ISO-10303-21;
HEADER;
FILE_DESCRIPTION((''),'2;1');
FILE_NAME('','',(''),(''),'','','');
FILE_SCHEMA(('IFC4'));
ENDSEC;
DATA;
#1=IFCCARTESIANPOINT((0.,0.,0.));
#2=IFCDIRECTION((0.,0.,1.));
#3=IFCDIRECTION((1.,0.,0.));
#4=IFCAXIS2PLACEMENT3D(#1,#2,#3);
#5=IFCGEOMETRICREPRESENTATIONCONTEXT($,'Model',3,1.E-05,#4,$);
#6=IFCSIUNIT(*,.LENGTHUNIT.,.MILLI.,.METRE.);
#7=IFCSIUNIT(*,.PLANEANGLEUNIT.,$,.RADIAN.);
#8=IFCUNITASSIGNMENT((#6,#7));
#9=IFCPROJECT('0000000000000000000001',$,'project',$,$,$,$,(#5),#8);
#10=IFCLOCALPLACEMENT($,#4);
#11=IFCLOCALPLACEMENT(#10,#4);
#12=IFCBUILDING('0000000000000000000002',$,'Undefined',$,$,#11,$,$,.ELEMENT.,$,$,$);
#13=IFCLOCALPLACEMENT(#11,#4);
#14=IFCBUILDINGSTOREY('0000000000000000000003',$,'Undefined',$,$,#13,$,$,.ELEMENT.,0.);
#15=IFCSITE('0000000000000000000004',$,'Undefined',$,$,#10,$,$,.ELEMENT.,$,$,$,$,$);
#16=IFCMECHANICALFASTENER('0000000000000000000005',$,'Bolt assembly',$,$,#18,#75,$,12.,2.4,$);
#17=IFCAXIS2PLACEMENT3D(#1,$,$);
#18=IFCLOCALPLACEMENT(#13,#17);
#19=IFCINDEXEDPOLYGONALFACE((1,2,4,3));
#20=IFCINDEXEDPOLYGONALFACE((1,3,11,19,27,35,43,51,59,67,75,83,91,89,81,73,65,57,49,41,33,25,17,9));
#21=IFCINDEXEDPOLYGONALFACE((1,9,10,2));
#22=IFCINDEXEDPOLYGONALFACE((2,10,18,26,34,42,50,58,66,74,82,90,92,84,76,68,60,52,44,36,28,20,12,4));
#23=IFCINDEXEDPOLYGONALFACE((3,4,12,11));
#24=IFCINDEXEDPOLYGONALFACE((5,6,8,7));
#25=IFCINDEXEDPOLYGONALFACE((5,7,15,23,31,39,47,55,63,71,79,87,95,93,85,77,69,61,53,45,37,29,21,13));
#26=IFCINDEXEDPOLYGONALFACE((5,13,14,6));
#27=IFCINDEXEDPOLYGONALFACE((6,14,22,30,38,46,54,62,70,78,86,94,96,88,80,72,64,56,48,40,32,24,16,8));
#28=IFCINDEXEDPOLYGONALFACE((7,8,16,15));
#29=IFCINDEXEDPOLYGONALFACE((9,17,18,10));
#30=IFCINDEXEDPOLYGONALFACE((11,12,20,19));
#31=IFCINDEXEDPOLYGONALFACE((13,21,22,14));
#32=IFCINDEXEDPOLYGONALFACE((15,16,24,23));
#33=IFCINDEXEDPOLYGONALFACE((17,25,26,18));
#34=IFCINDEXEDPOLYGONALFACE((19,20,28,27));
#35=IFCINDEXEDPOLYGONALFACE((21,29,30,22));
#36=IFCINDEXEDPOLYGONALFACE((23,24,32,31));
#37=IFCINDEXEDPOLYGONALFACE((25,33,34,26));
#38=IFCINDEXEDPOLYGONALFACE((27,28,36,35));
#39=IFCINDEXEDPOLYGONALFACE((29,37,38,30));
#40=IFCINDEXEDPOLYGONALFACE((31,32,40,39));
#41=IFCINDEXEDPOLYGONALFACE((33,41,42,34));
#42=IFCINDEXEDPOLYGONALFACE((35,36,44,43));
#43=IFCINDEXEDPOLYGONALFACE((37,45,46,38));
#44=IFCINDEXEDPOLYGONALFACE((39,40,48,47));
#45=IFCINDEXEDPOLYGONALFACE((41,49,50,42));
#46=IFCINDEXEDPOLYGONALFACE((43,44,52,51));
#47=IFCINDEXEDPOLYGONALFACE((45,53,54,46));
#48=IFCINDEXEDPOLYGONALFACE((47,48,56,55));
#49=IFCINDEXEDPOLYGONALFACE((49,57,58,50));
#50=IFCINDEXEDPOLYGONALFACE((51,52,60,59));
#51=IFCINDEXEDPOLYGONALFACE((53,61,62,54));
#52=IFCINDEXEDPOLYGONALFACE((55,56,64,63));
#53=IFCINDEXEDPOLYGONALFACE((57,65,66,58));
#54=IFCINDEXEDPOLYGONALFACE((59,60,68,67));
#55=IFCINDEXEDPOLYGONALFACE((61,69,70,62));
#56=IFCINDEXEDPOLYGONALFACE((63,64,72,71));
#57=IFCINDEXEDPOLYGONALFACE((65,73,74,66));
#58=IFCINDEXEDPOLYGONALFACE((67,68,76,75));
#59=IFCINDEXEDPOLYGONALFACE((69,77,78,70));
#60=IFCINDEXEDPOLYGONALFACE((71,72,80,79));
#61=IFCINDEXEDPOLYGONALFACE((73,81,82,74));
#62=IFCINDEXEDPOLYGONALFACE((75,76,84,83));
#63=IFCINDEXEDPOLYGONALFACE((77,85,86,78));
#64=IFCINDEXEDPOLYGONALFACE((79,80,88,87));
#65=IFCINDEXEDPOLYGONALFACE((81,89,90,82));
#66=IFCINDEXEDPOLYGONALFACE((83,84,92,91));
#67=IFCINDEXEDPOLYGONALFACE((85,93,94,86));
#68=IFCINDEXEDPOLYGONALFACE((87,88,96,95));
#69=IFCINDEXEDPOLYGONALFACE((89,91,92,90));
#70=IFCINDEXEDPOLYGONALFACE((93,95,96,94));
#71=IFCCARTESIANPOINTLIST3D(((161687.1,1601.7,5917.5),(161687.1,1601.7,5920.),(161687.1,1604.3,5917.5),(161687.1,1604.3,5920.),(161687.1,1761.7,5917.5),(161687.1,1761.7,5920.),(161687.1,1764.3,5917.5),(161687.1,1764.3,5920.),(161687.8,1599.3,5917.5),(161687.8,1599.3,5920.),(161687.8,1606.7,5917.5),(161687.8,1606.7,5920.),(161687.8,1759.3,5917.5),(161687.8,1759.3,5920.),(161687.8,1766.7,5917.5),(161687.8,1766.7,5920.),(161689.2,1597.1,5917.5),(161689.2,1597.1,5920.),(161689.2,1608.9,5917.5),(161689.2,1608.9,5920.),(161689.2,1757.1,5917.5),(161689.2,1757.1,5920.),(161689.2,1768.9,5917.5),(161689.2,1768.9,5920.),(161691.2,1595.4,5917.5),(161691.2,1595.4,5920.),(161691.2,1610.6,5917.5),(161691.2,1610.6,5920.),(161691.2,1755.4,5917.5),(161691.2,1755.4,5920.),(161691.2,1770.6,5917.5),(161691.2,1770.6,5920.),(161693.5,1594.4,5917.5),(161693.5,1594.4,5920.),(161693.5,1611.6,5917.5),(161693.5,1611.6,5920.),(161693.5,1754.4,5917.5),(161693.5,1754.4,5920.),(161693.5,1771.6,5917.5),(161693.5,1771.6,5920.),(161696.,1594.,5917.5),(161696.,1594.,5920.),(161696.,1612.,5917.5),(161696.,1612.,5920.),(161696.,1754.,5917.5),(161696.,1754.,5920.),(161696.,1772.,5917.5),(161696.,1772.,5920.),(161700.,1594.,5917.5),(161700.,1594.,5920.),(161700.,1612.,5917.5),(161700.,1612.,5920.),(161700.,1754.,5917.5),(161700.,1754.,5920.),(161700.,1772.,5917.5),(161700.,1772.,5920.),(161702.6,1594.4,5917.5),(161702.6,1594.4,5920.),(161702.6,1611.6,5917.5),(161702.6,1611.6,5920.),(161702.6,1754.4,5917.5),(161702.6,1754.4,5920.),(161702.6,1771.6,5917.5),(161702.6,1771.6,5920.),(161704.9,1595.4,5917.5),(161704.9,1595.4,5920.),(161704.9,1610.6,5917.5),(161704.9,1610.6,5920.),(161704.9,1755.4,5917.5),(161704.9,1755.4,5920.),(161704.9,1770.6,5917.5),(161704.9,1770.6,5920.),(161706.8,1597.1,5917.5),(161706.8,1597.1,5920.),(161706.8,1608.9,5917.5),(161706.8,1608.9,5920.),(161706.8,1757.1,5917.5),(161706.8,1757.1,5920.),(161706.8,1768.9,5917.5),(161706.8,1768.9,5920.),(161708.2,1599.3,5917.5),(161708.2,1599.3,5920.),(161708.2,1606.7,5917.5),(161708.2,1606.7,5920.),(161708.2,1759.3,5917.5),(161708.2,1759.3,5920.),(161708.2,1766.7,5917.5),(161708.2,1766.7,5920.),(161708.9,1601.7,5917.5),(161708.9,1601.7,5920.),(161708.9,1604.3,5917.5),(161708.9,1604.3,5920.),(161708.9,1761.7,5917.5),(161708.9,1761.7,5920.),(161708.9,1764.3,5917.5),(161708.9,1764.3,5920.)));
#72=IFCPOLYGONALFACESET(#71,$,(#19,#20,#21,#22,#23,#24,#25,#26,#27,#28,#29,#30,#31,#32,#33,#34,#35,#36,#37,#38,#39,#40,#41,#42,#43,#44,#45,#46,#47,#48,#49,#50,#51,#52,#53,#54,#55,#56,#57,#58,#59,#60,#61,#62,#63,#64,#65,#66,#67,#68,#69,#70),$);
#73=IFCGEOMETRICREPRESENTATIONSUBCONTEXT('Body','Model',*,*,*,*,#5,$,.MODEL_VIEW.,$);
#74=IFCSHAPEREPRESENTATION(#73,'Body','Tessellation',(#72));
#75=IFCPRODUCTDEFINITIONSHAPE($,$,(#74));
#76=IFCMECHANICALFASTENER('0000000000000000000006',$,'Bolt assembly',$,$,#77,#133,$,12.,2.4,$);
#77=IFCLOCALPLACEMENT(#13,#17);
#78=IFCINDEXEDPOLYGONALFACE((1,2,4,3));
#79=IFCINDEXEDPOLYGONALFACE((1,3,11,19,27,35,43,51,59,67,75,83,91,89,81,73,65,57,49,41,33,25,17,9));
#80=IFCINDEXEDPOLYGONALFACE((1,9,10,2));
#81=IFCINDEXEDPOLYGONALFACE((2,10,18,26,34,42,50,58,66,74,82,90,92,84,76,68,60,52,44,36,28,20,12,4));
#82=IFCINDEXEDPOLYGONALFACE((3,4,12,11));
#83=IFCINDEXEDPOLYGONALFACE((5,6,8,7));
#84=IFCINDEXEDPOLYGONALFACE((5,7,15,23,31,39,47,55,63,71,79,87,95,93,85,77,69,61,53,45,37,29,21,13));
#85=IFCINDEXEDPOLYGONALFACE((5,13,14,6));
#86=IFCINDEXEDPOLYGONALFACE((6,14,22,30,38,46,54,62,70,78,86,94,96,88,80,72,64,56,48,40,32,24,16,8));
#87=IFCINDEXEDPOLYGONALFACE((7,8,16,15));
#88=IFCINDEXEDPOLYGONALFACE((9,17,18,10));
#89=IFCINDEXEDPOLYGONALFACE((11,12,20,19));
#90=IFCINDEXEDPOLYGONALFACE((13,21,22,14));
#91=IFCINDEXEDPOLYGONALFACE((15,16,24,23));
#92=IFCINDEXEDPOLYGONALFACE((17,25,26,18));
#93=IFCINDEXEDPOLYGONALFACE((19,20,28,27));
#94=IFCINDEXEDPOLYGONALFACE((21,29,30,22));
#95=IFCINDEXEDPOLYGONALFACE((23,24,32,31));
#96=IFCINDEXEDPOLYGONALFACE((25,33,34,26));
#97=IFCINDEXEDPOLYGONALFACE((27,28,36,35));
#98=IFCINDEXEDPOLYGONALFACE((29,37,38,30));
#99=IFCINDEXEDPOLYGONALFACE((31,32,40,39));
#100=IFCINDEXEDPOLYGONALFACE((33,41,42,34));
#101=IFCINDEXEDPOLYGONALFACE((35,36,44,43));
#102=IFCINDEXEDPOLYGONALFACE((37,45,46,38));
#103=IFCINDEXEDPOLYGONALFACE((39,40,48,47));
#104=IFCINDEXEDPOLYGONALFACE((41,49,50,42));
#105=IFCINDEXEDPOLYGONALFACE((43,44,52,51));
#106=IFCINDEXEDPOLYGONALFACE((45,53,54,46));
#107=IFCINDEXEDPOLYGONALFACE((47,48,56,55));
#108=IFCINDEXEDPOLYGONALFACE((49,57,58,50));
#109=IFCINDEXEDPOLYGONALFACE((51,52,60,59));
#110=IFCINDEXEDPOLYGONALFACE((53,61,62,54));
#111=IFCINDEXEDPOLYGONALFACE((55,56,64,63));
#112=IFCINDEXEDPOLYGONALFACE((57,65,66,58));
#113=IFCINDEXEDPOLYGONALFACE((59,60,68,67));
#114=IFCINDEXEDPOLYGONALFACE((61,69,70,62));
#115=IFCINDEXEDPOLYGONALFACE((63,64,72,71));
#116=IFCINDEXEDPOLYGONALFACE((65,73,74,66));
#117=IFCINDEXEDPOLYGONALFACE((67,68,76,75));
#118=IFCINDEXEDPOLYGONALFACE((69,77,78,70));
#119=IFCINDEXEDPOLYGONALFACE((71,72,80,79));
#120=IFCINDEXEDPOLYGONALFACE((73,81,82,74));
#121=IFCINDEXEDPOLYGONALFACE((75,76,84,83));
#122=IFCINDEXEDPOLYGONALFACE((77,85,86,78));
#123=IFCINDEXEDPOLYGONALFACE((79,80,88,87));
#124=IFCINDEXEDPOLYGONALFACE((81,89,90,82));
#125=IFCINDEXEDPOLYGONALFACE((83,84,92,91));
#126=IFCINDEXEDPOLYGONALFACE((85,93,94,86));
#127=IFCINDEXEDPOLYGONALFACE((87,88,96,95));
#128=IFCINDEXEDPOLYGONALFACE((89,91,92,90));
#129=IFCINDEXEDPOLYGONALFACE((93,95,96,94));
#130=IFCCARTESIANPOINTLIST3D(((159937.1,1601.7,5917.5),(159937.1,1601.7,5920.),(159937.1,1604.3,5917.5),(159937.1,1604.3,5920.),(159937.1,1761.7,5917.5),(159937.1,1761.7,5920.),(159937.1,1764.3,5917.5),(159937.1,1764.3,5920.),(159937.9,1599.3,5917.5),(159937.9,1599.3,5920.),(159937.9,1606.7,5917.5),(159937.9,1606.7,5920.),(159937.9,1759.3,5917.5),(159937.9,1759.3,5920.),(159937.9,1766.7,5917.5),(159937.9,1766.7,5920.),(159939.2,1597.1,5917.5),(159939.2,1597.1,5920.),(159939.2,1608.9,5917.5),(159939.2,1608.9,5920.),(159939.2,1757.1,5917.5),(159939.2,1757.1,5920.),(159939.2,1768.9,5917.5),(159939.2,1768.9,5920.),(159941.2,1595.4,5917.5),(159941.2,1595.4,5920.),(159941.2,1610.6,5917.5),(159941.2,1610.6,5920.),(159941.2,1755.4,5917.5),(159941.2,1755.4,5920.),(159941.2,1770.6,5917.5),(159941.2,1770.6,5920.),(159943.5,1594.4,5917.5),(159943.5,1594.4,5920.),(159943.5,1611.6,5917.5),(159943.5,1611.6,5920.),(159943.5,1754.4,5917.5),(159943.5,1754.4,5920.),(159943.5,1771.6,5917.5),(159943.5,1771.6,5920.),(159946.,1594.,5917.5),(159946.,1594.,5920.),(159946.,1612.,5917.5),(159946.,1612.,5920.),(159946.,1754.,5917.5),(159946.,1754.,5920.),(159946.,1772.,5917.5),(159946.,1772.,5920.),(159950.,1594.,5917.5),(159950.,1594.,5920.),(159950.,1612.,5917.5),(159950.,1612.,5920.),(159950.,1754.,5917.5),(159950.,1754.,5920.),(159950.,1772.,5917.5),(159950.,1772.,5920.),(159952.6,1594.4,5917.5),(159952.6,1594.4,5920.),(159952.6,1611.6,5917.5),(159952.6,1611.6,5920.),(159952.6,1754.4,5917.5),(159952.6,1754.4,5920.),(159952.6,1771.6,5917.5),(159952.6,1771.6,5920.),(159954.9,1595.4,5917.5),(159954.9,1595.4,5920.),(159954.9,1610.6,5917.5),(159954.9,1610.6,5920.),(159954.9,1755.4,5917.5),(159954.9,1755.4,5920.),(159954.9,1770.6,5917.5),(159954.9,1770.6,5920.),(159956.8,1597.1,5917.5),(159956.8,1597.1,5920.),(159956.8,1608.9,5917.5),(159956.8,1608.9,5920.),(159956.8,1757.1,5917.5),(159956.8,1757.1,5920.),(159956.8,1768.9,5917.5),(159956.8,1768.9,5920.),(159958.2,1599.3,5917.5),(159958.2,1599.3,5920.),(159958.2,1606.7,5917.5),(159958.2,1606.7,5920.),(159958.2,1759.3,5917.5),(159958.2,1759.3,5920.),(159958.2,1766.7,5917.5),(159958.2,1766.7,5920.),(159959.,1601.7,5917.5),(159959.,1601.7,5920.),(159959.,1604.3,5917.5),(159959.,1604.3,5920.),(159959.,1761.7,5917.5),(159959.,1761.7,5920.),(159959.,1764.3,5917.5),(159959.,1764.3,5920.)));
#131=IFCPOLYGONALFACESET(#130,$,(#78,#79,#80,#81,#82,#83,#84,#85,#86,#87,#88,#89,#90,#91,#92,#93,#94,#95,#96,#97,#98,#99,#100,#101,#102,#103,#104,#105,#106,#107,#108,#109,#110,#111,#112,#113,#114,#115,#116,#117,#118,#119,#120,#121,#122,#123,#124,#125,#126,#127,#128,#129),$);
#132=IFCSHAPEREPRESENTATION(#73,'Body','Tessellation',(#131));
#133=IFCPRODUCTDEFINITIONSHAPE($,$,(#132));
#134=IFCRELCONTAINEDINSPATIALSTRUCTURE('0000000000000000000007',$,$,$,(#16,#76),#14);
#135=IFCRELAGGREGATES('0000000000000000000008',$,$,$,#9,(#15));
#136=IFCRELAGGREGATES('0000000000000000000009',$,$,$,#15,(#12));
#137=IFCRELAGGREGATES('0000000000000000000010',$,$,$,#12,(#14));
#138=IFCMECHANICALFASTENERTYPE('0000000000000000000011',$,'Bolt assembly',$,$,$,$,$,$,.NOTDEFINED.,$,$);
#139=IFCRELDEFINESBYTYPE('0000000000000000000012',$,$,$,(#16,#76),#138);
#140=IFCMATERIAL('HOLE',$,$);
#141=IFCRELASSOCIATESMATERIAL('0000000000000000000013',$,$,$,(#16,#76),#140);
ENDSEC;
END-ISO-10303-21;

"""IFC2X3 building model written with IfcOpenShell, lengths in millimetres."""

from ifc_helpers import new_model, si_unit, frame, frame_2d, origin_with_axes, place, context, subcontext, project, spatial, polyline, circle_curve, parameter, trimmed, segment, composite_curve, outline, extrude, source, transform, mapped, material, type_object, element, save


model = new_model("IFC2X3")

# Units and contexts
model_context = context("Model", 3, precision=1e-05, world=origin_with_axes())
body_context = subcontext(model_context, "Body", "Model", "MODEL_VIEW")
ifc_project = project(units=[si_unit("LENGTHUNIT", "METRE", prefix="MILLI"), si_unit("PLANEANGLEUNIT", "RADIAN")], contexts=[model_context])

# Site, building, storey
site_placement = place(None, origin_with_axes())
site = spatial("IfcSite", under=ifc_project, at=site_placement, Name="Undefined", CompositionType="ELEMENT")
building_placement = place(site_placement, origin_with_axes())
building = spatial("IfcBuilding", under=site, at=building_placement, Name="Undefined", CompositionType="ELEMENT")
storey_placement = place(building_placement, origin_with_axes())
storey = spatial("IfcBuildingStorey", under=building, at=storey_placement, Name="Undefined", CompositionType="ELEMENT", Elevation=0.0)

# Mechanical fasteners
ifc_material_1 = material(Name="HOLE")
mechanical_fastener_type = type_object("IfcMechanicalFastenerType", Name="Bolt assembly")
shared_shape_1 = source(origin_with_axes(), body_context, "Body", "SweptSolid", [
    extrude(outline(composite_curve([segment(polyline([(-2.0, 9.0), (2.0, 9.0)]), True, "CONTINUOUS"), segment(trimmed(circle_curve(frame_2d((2.0, 0.0), x_axis=(0.0, 1.0)), 9.0), [parameter(0.0)], [parameter(3.141593)], False, "PARAMETER"), True, "CONTINUOUS"), segment(polyline([(2.0, -9.0), (-2.0, -9.0)]), True, "CONTINUOUS"), segment(trimmed(circle_curve(frame_2d((-2.0, 0.0), x_axis=(0.0, -1.0)), 9.0), [parameter(0.0)], [parameter(3.141593)], False, "PARAMETER"), True, "DISCONTINUOUS")], self_intersect=False)), frame((0.0, -2.4, 0.0), z_axis=(0.0, 1.0, 0.0), x_axis=(1.0, 0.0, 0.0)), (0.0, 0.0, 1.0), 2.5),
])
mechanical_fastener_1_placement = place(storey_placement, frame((161698.0, 1683.0, 5917.6), z_axis=(0.0, -1.0, 0.0), x_axis=(-1.0, 0.0, 0.0)))
element("IfcMechanicalFastener", 1, at=mechanical_fastener_1_placement, inside=storey, type_object=mechanical_fastener_type, material=ifc_material_1, Name="Bolt assembly", NominalDiameter=12.0, NominalLength=2.4, context=body_context, shape_type="MappedRepresentation", body=[
    mapped(shared_shape_1, transform((0.0, 0.0, -80.0))),
    mapped(shared_shape_1, transform((0.0, 0.0, 80.0))),
])
shared_shape_2 = source(origin_with_axes(), body_context, "Body", "SweptSolid", [
    extrude(outline(composite_curve([segment(polyline([(-2.0, 9.0), (2.0, 9.0)]), True, "CONTINUOUS"), segment(trimmed(circle_curve(frame_2d((2.0, 0.0), x_axis=(0.0, 1.0)), 9.0), [parameter(0.0)], [parameter(3.141593)], False, "PARAMETER"), True, "CONTINUOUS"), segment(polyline([(2.0, -9.0), (-2.0, -9.0)]), True, "CONTINUOUS"), segment(trimmed(circle_curve(frame_2d((-2.0, 0.0), x_axis=(0.0, -1.0)), 9.0), [parameter(0.0)], [parameter(3.141593)], False, "PARAMETER"), True, "DISCONTINUOUS")], self_intersect=False)), frame((0.0, -2.4, 0.0), z_axis=(0.0, 1.0, 0.0), x_axis=(1.0, 0.0, 0.0)), (0.0, 0.0, 1.0), 2.5),
])
mechanical_fastener_2_placement = place(storey_placement, frame((159948.0, 1683.0, 5917.6), z_axis=(0.0, -1.0, 0.0), x_axis=(-1.0, 0.0, 0.0)))
element("IfcMechanicalFastener", 2, at=mechanical_fastener_2_placement, inside=storey, type_object=mechanical_fastener_type, material=ifc_material_1, Name="Bolt assembly", NominalDiameter=12.0, NominalLength=2.4, context=body_context, shape_type="MappedRepresentation", body=[
    mapped(shared_shape_2, transform((0.0, 0.0, -80.0))),
    mapped(shared_shape_2, transform((0.0, 0.0, 80.0))),
])

save(model, "model.ifc")
